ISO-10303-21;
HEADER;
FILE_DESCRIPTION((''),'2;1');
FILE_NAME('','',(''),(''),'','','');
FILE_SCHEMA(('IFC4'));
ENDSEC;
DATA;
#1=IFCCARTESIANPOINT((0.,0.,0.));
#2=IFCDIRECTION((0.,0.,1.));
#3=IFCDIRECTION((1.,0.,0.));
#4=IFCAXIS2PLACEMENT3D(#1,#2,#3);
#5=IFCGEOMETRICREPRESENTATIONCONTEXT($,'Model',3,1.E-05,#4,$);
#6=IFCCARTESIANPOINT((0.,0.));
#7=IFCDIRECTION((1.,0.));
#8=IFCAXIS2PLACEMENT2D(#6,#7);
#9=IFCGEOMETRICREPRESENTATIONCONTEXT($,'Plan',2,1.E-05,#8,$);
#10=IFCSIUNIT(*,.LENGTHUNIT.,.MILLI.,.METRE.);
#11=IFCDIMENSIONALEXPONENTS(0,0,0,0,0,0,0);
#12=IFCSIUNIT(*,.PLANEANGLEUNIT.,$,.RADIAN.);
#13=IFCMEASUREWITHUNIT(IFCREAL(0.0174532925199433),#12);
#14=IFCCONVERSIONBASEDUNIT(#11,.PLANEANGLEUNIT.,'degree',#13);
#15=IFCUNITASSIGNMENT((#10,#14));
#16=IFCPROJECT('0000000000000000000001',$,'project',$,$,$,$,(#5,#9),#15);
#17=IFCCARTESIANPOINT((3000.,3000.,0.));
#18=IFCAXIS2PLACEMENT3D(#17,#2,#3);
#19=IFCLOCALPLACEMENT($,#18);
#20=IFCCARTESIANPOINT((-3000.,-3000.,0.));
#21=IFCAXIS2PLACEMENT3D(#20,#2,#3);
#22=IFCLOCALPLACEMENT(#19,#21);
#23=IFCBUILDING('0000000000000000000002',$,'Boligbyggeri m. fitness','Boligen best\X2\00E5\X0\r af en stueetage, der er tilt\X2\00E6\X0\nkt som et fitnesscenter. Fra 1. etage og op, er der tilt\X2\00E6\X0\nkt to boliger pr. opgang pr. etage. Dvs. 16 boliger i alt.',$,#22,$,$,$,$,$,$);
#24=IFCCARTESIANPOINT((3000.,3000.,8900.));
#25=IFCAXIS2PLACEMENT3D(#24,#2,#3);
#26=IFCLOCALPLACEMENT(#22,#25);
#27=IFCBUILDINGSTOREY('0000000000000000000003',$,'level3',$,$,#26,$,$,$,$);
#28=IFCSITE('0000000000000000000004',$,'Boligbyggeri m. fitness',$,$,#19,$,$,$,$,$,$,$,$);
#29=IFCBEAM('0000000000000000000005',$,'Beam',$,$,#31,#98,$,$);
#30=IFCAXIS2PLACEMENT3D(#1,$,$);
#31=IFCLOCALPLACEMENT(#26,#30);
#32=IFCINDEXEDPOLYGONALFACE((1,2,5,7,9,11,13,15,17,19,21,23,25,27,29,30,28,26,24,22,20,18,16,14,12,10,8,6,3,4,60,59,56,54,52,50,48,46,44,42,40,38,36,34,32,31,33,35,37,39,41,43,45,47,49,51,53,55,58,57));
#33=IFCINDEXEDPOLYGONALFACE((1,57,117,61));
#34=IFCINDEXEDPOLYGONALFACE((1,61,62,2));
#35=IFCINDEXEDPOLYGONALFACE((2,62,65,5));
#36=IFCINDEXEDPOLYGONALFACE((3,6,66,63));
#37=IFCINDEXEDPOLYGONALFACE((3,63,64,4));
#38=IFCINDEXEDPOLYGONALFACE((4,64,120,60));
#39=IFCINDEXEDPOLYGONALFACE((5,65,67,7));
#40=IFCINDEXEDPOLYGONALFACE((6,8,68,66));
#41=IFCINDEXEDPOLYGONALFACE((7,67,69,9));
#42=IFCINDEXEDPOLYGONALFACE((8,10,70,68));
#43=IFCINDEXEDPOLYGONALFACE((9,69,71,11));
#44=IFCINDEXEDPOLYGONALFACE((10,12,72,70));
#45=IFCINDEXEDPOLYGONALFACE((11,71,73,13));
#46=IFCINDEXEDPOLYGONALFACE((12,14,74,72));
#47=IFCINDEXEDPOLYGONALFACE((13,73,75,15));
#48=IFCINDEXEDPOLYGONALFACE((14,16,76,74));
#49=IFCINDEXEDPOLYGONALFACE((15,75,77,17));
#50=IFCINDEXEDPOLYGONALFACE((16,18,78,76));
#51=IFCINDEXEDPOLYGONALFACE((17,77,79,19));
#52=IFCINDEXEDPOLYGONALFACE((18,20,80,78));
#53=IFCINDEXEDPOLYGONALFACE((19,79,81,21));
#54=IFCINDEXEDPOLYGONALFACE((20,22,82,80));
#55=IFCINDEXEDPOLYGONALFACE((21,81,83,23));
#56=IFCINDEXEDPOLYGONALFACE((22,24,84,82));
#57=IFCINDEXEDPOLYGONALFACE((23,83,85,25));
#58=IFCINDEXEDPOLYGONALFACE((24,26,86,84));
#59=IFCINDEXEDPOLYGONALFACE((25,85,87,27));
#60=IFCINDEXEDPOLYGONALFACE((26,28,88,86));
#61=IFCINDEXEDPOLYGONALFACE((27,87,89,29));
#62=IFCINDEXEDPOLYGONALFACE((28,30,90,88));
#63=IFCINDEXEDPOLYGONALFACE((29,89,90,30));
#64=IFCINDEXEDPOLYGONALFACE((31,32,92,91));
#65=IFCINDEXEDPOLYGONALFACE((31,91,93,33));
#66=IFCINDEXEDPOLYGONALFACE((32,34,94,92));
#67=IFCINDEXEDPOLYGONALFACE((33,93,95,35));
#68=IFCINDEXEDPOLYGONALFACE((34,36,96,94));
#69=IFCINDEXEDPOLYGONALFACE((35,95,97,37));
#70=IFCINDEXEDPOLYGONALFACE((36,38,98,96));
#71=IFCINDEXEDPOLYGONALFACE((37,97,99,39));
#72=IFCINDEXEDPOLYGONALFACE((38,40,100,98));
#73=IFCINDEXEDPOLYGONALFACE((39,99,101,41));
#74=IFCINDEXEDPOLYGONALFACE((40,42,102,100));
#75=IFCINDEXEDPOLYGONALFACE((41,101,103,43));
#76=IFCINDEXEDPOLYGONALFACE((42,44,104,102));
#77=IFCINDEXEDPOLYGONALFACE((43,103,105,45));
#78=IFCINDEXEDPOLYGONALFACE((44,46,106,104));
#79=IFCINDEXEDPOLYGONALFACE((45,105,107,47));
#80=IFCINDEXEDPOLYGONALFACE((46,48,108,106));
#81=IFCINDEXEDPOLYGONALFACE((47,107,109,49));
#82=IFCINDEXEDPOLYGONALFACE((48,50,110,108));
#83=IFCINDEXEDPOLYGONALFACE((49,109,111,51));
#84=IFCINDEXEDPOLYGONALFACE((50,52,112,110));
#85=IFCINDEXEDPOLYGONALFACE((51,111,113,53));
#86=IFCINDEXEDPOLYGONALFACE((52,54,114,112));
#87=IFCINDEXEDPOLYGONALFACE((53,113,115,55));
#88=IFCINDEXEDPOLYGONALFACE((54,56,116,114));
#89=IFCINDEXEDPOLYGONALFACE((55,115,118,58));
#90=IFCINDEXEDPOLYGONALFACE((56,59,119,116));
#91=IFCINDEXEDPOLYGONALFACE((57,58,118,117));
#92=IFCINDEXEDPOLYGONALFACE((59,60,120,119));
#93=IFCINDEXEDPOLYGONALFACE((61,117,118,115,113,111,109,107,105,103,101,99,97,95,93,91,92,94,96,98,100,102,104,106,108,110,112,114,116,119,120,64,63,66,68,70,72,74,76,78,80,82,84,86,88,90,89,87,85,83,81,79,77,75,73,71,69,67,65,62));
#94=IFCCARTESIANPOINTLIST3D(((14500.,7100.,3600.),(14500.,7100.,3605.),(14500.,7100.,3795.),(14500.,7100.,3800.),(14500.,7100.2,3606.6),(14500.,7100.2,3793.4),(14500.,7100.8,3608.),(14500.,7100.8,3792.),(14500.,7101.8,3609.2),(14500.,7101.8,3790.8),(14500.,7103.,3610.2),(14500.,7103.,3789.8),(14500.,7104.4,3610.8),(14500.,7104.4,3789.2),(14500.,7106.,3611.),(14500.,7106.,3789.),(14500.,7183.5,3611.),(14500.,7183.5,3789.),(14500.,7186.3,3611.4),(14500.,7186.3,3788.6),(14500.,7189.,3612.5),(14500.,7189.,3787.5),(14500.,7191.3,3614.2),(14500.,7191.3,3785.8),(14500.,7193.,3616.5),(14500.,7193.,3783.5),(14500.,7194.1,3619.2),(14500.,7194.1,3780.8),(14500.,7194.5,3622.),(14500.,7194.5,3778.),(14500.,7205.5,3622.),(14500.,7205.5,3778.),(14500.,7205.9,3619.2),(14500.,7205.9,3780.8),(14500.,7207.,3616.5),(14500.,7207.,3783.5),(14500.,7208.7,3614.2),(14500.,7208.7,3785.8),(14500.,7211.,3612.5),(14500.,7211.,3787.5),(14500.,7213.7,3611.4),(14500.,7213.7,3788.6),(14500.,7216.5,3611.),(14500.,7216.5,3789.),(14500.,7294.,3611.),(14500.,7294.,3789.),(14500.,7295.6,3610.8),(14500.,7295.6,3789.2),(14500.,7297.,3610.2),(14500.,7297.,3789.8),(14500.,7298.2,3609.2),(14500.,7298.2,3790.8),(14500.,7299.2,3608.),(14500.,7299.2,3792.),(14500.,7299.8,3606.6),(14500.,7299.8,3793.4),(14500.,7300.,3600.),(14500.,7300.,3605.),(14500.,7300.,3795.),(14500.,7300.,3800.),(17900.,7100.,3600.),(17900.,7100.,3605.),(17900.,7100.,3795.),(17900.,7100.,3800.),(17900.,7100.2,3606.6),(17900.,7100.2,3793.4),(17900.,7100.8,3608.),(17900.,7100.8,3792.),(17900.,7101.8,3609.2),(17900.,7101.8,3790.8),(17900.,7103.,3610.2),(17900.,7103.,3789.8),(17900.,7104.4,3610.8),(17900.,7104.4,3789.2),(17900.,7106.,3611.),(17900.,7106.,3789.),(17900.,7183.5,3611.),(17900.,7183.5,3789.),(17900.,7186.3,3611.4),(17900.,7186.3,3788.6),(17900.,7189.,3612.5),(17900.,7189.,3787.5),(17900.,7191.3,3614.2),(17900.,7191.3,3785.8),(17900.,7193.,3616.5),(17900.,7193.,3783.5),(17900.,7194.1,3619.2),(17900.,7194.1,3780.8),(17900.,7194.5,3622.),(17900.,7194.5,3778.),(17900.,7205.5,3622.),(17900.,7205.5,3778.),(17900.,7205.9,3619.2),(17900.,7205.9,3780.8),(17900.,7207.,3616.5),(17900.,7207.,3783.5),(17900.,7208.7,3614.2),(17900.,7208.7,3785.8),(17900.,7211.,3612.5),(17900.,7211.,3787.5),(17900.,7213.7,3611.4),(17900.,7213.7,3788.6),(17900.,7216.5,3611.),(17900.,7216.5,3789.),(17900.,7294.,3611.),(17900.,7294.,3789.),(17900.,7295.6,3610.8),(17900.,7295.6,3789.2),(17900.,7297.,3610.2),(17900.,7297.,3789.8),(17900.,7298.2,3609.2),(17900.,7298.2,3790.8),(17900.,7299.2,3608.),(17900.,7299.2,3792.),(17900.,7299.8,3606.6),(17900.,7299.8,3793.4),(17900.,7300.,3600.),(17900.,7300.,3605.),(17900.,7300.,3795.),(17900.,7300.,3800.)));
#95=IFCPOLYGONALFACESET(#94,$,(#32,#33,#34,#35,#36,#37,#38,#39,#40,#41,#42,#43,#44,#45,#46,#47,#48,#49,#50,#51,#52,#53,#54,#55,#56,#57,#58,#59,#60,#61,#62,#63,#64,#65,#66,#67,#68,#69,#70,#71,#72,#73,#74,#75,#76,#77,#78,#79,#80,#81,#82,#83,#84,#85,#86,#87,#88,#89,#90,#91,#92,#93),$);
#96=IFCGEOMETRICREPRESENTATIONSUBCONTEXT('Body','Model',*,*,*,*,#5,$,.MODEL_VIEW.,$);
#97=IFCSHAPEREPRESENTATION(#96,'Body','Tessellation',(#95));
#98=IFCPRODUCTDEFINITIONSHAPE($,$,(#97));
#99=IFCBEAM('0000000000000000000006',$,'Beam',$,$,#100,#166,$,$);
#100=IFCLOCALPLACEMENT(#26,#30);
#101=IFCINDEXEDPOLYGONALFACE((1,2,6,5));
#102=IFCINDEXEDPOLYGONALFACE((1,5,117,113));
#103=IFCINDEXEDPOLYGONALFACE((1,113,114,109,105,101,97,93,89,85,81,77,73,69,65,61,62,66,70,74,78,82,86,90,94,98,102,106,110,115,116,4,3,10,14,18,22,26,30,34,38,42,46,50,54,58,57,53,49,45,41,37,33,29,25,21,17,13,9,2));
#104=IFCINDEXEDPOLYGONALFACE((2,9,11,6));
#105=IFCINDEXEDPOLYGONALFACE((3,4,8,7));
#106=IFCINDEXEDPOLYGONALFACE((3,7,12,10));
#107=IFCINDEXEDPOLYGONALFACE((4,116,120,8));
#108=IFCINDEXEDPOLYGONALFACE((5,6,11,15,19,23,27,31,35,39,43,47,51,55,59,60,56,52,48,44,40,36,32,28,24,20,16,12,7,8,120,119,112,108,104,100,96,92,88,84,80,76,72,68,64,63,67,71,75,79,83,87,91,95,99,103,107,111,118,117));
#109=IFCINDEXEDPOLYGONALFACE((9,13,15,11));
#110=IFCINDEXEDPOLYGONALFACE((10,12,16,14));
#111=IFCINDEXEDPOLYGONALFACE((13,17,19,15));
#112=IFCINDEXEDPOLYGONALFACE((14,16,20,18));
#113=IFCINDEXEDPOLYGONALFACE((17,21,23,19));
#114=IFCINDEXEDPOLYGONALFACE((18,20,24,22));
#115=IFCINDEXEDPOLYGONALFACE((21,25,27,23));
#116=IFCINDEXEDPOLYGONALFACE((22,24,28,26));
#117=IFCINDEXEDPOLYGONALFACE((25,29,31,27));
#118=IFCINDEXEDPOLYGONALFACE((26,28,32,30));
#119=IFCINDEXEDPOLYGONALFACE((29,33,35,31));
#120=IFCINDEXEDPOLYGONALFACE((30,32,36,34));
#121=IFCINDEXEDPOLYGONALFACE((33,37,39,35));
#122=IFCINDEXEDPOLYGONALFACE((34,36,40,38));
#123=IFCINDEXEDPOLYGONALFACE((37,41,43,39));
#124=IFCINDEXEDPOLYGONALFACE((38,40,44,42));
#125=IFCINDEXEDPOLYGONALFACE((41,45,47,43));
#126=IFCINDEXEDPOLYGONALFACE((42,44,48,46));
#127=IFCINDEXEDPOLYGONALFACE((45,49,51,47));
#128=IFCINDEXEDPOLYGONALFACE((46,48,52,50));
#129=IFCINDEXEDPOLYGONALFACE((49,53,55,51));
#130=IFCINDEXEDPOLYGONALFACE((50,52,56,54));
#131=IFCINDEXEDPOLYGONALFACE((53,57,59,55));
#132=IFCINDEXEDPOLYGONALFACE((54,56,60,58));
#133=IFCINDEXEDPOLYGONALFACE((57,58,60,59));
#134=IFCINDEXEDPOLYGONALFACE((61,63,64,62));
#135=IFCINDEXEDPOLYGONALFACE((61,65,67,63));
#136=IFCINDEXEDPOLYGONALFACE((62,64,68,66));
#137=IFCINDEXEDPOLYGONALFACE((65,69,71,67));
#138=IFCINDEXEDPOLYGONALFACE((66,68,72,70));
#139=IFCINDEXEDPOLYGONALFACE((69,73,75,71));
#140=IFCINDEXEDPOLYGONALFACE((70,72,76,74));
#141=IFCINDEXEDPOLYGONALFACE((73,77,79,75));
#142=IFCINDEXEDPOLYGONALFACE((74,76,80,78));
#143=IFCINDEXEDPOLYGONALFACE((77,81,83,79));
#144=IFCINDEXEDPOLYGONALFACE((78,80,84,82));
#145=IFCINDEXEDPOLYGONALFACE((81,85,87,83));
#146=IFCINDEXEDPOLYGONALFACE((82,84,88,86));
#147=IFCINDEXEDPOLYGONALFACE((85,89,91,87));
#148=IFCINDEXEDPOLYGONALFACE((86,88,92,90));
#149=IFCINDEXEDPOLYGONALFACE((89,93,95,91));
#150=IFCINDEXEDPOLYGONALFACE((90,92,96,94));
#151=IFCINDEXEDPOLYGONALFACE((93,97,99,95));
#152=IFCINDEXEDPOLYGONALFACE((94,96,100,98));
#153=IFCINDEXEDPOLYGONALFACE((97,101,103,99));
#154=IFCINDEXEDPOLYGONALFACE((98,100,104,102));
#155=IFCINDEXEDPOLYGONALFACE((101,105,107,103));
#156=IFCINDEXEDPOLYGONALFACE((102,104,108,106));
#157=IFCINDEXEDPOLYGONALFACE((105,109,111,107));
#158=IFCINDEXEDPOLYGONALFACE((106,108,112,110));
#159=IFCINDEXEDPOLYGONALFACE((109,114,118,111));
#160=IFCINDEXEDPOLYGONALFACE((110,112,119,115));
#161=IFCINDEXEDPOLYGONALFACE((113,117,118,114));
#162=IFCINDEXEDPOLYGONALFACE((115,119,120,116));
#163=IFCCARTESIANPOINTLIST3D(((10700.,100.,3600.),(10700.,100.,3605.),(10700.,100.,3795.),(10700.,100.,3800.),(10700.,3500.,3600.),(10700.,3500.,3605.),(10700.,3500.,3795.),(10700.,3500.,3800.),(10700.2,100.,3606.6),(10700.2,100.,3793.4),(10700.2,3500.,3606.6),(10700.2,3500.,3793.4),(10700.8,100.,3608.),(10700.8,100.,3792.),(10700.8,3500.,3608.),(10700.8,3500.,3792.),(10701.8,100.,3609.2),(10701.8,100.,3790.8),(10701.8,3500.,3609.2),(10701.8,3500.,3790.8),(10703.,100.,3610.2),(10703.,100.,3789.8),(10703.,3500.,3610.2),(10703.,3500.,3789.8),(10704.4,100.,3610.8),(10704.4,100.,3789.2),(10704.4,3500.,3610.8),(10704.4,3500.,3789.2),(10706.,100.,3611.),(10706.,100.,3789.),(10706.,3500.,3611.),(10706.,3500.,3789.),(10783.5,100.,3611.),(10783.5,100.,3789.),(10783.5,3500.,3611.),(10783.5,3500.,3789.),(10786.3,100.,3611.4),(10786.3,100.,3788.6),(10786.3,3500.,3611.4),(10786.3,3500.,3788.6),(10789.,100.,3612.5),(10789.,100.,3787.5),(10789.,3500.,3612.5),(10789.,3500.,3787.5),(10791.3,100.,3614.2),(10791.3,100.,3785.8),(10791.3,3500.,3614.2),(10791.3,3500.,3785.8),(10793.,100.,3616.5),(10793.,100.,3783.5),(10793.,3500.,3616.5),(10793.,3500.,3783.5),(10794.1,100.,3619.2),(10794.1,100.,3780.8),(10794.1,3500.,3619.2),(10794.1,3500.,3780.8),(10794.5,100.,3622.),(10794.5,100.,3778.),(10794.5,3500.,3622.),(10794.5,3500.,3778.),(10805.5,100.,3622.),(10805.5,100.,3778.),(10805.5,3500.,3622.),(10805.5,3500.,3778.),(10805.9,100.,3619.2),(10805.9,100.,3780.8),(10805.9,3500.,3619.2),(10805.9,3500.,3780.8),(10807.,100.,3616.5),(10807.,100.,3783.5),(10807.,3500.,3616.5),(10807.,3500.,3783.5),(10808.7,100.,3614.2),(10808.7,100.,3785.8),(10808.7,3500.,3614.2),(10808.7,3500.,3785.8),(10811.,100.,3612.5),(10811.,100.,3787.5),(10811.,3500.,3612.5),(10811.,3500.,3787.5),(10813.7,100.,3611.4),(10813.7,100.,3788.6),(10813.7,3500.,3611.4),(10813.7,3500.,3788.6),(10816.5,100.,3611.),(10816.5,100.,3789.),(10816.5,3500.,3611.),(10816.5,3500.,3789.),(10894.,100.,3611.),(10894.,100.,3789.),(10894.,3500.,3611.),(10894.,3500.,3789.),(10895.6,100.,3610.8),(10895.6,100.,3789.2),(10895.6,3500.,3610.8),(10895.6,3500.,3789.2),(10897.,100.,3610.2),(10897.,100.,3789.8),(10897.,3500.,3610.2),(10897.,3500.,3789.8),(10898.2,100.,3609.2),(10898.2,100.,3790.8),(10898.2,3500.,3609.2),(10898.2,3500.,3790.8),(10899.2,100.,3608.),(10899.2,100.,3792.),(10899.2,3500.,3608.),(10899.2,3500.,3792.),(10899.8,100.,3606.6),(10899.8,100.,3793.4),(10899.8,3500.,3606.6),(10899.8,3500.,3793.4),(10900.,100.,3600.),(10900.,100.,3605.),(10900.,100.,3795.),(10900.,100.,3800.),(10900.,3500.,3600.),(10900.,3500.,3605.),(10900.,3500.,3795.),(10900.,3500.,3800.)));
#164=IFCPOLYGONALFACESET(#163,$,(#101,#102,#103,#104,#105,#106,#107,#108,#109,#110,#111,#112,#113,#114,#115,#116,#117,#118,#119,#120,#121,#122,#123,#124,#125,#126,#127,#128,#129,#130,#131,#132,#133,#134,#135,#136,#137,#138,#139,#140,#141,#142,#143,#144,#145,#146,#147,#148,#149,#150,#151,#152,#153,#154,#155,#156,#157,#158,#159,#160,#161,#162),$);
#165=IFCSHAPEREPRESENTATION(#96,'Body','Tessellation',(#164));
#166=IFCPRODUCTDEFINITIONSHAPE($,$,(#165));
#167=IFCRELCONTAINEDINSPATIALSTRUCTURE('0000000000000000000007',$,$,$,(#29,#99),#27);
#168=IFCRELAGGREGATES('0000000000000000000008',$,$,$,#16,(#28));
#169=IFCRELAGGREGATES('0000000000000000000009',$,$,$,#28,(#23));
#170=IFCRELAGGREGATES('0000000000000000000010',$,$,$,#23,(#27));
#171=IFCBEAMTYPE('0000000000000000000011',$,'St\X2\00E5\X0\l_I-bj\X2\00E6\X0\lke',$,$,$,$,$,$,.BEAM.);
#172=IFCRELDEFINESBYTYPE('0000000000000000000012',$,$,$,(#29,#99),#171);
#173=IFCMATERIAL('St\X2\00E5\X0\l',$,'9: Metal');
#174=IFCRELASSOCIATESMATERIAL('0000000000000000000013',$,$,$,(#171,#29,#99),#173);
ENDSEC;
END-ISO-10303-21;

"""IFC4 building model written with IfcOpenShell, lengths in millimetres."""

from ifc_helpers import new_model, entity, si_unit, converted_unit, frame, origin_with_axes, origin_2d_with_axis, place, context, subcontext, project, spatial, i_section, extrude, material, material_profile, profile_set, profile_usage, type_object, element, save


model = new_model("IFC4")

# Units and contexts
model_context = context("Model", 3, precision=1e-05, world=origin_with_axes())
plan_context = context("Plan", 2, precision=1e-05, world=origin_2d_with_axis())
body_context = subcontext(model_context, "Body", "Model", "MODEL_VIEW")
ifc_project = project(units=[si_unit("LENGTHUNIT", "METRE", prefix="MILLI"), converted_unit("PLANEANGLEUNIT", "degree", entity("IfcReal", 0.0174532925199433), si_unit("PLANEANGLEUNIT", "RADIAN"), dimensions=[0, 0, 0, 0, 0, 0, 0])], contexts=[model_context, plan_context])

# Site, building, storey
site_placement = place(None, frame((3000.0, 3000.0, 0.0), z_axis=(0.0, 0.0, 1.0), x_axis=(1.0, 0.0, 0.0)))
site = spatial("IfcSite", under=ifc_project, at=site_placement, Name="Boligbyggeri m. fitness")
building_placement = place(site_placement, frame((-3000.0, -3000.0, 0.0), z_axis=(0.0, 0.0, 1.0), x_axis=(1.0, 0.0, 0.0)))
building = spatial("IfcBuilding", under=site, at=building_placement, Name="Boligbyggeri m. fitness", Description="Boligen består af en stueetage, der er tiltænkt som et fitnesscenter. Fra 1. etage og op, er der tiltænkt to boliger pr. opgang pr. etage. Dvs. 16 boliger i alt.")
storey_placement = place(building_placement, frame((3000.0, 3000.0, 8900.0), z_axis=(0.0, 0.0, 1.0), x_axis=(1.0, 0.0, 0.0)))
storey = spatial("IfcBuildingStorey", under=building, at=storey_placement, Name="level3")

# Beams
ifc_material_1 = material(Name="Stål", Category="9: Metal")
ifc_material_profile_1 = material_profile(ifc_material_1, i_section(OverallWidth=200.0, OverallDepth=200.0, WebThickness=11.0, FlangeThickness=11.0, FilletRadius=11.0, FlangeEdgeRadius=6.0), Name="Stål", Category="9: Metal")
ifc_profile_set_1 = profile_set([ifc_material_profile_1], Name="NY_I-Profil")
beam_type = type_object("IfcBeamType", Name="Stål_I-bjælke", PredefinedType="BEAM", material=ifc_profile_set_1)
ifc_profile_usage_1 = profile_usage(ifc_profile_set_1, cardinal=7)
beam_1_placement = place(storey_placement, frame((14500.0, 7300.0, 3800.0), z_axis=(1.0, 0.0, 0.0), x_axis=(0.0, 1.0, 0.0)))
element("IfcBeam", 1, at=beam_1_placement, inside=storey, type_object=beam_type, material=ifc_profile_usage_1, Name="Beam", context=body_context, shape_type="SweptSolid", body=[
    extrude(i_section(OverallWidth=200.0, OverallDepth=200.0, WebThickness=11.0, FlangeThickness=11.0, FilletRadius=11.0, FlangeEdgeRadius=6.0), frame((-100.0, -100.0, 0.0), z_axis=(0.0, 0.0, 1.0), x_axis=(1.0, 0.0, 0.0)), (0.0, 0.0, 1.0), 3400.0),
])
ifc_profile_usage_2 = profile_usage(ifc_profile_set_1, cardinal=9)
beam_2_placement = place(storey_placement, frame((10900.0, 100.0, 3800.0), z_axis=(0.0, 1.0, 0.0), x_axis=(-1.0, 0.0, 0.0)))
element("IfcBeam", 2, at=beam_2_placement, inside=storey, type_object=beam_type, material=ifc_profile_usage_2, Name="Beam", context=body_context, shape_type="SweptSolid", body=[
    extrude(i_section(OverallWidth=200.0, OverallDepth=200.0, WebThickness=11.0, FlangeThickness=11.0, FilletRadius=11.0, FlangeEdgeRadius=6.0), frame((100.0, -100.0, 0.0), z_axis=(0.0, 0.0, 1.0), x_axis=(1.0, 0.0, 0.0)), (0.0, 0.0, 1.0), 3400.0),
])

save(model, "model.ifc")
